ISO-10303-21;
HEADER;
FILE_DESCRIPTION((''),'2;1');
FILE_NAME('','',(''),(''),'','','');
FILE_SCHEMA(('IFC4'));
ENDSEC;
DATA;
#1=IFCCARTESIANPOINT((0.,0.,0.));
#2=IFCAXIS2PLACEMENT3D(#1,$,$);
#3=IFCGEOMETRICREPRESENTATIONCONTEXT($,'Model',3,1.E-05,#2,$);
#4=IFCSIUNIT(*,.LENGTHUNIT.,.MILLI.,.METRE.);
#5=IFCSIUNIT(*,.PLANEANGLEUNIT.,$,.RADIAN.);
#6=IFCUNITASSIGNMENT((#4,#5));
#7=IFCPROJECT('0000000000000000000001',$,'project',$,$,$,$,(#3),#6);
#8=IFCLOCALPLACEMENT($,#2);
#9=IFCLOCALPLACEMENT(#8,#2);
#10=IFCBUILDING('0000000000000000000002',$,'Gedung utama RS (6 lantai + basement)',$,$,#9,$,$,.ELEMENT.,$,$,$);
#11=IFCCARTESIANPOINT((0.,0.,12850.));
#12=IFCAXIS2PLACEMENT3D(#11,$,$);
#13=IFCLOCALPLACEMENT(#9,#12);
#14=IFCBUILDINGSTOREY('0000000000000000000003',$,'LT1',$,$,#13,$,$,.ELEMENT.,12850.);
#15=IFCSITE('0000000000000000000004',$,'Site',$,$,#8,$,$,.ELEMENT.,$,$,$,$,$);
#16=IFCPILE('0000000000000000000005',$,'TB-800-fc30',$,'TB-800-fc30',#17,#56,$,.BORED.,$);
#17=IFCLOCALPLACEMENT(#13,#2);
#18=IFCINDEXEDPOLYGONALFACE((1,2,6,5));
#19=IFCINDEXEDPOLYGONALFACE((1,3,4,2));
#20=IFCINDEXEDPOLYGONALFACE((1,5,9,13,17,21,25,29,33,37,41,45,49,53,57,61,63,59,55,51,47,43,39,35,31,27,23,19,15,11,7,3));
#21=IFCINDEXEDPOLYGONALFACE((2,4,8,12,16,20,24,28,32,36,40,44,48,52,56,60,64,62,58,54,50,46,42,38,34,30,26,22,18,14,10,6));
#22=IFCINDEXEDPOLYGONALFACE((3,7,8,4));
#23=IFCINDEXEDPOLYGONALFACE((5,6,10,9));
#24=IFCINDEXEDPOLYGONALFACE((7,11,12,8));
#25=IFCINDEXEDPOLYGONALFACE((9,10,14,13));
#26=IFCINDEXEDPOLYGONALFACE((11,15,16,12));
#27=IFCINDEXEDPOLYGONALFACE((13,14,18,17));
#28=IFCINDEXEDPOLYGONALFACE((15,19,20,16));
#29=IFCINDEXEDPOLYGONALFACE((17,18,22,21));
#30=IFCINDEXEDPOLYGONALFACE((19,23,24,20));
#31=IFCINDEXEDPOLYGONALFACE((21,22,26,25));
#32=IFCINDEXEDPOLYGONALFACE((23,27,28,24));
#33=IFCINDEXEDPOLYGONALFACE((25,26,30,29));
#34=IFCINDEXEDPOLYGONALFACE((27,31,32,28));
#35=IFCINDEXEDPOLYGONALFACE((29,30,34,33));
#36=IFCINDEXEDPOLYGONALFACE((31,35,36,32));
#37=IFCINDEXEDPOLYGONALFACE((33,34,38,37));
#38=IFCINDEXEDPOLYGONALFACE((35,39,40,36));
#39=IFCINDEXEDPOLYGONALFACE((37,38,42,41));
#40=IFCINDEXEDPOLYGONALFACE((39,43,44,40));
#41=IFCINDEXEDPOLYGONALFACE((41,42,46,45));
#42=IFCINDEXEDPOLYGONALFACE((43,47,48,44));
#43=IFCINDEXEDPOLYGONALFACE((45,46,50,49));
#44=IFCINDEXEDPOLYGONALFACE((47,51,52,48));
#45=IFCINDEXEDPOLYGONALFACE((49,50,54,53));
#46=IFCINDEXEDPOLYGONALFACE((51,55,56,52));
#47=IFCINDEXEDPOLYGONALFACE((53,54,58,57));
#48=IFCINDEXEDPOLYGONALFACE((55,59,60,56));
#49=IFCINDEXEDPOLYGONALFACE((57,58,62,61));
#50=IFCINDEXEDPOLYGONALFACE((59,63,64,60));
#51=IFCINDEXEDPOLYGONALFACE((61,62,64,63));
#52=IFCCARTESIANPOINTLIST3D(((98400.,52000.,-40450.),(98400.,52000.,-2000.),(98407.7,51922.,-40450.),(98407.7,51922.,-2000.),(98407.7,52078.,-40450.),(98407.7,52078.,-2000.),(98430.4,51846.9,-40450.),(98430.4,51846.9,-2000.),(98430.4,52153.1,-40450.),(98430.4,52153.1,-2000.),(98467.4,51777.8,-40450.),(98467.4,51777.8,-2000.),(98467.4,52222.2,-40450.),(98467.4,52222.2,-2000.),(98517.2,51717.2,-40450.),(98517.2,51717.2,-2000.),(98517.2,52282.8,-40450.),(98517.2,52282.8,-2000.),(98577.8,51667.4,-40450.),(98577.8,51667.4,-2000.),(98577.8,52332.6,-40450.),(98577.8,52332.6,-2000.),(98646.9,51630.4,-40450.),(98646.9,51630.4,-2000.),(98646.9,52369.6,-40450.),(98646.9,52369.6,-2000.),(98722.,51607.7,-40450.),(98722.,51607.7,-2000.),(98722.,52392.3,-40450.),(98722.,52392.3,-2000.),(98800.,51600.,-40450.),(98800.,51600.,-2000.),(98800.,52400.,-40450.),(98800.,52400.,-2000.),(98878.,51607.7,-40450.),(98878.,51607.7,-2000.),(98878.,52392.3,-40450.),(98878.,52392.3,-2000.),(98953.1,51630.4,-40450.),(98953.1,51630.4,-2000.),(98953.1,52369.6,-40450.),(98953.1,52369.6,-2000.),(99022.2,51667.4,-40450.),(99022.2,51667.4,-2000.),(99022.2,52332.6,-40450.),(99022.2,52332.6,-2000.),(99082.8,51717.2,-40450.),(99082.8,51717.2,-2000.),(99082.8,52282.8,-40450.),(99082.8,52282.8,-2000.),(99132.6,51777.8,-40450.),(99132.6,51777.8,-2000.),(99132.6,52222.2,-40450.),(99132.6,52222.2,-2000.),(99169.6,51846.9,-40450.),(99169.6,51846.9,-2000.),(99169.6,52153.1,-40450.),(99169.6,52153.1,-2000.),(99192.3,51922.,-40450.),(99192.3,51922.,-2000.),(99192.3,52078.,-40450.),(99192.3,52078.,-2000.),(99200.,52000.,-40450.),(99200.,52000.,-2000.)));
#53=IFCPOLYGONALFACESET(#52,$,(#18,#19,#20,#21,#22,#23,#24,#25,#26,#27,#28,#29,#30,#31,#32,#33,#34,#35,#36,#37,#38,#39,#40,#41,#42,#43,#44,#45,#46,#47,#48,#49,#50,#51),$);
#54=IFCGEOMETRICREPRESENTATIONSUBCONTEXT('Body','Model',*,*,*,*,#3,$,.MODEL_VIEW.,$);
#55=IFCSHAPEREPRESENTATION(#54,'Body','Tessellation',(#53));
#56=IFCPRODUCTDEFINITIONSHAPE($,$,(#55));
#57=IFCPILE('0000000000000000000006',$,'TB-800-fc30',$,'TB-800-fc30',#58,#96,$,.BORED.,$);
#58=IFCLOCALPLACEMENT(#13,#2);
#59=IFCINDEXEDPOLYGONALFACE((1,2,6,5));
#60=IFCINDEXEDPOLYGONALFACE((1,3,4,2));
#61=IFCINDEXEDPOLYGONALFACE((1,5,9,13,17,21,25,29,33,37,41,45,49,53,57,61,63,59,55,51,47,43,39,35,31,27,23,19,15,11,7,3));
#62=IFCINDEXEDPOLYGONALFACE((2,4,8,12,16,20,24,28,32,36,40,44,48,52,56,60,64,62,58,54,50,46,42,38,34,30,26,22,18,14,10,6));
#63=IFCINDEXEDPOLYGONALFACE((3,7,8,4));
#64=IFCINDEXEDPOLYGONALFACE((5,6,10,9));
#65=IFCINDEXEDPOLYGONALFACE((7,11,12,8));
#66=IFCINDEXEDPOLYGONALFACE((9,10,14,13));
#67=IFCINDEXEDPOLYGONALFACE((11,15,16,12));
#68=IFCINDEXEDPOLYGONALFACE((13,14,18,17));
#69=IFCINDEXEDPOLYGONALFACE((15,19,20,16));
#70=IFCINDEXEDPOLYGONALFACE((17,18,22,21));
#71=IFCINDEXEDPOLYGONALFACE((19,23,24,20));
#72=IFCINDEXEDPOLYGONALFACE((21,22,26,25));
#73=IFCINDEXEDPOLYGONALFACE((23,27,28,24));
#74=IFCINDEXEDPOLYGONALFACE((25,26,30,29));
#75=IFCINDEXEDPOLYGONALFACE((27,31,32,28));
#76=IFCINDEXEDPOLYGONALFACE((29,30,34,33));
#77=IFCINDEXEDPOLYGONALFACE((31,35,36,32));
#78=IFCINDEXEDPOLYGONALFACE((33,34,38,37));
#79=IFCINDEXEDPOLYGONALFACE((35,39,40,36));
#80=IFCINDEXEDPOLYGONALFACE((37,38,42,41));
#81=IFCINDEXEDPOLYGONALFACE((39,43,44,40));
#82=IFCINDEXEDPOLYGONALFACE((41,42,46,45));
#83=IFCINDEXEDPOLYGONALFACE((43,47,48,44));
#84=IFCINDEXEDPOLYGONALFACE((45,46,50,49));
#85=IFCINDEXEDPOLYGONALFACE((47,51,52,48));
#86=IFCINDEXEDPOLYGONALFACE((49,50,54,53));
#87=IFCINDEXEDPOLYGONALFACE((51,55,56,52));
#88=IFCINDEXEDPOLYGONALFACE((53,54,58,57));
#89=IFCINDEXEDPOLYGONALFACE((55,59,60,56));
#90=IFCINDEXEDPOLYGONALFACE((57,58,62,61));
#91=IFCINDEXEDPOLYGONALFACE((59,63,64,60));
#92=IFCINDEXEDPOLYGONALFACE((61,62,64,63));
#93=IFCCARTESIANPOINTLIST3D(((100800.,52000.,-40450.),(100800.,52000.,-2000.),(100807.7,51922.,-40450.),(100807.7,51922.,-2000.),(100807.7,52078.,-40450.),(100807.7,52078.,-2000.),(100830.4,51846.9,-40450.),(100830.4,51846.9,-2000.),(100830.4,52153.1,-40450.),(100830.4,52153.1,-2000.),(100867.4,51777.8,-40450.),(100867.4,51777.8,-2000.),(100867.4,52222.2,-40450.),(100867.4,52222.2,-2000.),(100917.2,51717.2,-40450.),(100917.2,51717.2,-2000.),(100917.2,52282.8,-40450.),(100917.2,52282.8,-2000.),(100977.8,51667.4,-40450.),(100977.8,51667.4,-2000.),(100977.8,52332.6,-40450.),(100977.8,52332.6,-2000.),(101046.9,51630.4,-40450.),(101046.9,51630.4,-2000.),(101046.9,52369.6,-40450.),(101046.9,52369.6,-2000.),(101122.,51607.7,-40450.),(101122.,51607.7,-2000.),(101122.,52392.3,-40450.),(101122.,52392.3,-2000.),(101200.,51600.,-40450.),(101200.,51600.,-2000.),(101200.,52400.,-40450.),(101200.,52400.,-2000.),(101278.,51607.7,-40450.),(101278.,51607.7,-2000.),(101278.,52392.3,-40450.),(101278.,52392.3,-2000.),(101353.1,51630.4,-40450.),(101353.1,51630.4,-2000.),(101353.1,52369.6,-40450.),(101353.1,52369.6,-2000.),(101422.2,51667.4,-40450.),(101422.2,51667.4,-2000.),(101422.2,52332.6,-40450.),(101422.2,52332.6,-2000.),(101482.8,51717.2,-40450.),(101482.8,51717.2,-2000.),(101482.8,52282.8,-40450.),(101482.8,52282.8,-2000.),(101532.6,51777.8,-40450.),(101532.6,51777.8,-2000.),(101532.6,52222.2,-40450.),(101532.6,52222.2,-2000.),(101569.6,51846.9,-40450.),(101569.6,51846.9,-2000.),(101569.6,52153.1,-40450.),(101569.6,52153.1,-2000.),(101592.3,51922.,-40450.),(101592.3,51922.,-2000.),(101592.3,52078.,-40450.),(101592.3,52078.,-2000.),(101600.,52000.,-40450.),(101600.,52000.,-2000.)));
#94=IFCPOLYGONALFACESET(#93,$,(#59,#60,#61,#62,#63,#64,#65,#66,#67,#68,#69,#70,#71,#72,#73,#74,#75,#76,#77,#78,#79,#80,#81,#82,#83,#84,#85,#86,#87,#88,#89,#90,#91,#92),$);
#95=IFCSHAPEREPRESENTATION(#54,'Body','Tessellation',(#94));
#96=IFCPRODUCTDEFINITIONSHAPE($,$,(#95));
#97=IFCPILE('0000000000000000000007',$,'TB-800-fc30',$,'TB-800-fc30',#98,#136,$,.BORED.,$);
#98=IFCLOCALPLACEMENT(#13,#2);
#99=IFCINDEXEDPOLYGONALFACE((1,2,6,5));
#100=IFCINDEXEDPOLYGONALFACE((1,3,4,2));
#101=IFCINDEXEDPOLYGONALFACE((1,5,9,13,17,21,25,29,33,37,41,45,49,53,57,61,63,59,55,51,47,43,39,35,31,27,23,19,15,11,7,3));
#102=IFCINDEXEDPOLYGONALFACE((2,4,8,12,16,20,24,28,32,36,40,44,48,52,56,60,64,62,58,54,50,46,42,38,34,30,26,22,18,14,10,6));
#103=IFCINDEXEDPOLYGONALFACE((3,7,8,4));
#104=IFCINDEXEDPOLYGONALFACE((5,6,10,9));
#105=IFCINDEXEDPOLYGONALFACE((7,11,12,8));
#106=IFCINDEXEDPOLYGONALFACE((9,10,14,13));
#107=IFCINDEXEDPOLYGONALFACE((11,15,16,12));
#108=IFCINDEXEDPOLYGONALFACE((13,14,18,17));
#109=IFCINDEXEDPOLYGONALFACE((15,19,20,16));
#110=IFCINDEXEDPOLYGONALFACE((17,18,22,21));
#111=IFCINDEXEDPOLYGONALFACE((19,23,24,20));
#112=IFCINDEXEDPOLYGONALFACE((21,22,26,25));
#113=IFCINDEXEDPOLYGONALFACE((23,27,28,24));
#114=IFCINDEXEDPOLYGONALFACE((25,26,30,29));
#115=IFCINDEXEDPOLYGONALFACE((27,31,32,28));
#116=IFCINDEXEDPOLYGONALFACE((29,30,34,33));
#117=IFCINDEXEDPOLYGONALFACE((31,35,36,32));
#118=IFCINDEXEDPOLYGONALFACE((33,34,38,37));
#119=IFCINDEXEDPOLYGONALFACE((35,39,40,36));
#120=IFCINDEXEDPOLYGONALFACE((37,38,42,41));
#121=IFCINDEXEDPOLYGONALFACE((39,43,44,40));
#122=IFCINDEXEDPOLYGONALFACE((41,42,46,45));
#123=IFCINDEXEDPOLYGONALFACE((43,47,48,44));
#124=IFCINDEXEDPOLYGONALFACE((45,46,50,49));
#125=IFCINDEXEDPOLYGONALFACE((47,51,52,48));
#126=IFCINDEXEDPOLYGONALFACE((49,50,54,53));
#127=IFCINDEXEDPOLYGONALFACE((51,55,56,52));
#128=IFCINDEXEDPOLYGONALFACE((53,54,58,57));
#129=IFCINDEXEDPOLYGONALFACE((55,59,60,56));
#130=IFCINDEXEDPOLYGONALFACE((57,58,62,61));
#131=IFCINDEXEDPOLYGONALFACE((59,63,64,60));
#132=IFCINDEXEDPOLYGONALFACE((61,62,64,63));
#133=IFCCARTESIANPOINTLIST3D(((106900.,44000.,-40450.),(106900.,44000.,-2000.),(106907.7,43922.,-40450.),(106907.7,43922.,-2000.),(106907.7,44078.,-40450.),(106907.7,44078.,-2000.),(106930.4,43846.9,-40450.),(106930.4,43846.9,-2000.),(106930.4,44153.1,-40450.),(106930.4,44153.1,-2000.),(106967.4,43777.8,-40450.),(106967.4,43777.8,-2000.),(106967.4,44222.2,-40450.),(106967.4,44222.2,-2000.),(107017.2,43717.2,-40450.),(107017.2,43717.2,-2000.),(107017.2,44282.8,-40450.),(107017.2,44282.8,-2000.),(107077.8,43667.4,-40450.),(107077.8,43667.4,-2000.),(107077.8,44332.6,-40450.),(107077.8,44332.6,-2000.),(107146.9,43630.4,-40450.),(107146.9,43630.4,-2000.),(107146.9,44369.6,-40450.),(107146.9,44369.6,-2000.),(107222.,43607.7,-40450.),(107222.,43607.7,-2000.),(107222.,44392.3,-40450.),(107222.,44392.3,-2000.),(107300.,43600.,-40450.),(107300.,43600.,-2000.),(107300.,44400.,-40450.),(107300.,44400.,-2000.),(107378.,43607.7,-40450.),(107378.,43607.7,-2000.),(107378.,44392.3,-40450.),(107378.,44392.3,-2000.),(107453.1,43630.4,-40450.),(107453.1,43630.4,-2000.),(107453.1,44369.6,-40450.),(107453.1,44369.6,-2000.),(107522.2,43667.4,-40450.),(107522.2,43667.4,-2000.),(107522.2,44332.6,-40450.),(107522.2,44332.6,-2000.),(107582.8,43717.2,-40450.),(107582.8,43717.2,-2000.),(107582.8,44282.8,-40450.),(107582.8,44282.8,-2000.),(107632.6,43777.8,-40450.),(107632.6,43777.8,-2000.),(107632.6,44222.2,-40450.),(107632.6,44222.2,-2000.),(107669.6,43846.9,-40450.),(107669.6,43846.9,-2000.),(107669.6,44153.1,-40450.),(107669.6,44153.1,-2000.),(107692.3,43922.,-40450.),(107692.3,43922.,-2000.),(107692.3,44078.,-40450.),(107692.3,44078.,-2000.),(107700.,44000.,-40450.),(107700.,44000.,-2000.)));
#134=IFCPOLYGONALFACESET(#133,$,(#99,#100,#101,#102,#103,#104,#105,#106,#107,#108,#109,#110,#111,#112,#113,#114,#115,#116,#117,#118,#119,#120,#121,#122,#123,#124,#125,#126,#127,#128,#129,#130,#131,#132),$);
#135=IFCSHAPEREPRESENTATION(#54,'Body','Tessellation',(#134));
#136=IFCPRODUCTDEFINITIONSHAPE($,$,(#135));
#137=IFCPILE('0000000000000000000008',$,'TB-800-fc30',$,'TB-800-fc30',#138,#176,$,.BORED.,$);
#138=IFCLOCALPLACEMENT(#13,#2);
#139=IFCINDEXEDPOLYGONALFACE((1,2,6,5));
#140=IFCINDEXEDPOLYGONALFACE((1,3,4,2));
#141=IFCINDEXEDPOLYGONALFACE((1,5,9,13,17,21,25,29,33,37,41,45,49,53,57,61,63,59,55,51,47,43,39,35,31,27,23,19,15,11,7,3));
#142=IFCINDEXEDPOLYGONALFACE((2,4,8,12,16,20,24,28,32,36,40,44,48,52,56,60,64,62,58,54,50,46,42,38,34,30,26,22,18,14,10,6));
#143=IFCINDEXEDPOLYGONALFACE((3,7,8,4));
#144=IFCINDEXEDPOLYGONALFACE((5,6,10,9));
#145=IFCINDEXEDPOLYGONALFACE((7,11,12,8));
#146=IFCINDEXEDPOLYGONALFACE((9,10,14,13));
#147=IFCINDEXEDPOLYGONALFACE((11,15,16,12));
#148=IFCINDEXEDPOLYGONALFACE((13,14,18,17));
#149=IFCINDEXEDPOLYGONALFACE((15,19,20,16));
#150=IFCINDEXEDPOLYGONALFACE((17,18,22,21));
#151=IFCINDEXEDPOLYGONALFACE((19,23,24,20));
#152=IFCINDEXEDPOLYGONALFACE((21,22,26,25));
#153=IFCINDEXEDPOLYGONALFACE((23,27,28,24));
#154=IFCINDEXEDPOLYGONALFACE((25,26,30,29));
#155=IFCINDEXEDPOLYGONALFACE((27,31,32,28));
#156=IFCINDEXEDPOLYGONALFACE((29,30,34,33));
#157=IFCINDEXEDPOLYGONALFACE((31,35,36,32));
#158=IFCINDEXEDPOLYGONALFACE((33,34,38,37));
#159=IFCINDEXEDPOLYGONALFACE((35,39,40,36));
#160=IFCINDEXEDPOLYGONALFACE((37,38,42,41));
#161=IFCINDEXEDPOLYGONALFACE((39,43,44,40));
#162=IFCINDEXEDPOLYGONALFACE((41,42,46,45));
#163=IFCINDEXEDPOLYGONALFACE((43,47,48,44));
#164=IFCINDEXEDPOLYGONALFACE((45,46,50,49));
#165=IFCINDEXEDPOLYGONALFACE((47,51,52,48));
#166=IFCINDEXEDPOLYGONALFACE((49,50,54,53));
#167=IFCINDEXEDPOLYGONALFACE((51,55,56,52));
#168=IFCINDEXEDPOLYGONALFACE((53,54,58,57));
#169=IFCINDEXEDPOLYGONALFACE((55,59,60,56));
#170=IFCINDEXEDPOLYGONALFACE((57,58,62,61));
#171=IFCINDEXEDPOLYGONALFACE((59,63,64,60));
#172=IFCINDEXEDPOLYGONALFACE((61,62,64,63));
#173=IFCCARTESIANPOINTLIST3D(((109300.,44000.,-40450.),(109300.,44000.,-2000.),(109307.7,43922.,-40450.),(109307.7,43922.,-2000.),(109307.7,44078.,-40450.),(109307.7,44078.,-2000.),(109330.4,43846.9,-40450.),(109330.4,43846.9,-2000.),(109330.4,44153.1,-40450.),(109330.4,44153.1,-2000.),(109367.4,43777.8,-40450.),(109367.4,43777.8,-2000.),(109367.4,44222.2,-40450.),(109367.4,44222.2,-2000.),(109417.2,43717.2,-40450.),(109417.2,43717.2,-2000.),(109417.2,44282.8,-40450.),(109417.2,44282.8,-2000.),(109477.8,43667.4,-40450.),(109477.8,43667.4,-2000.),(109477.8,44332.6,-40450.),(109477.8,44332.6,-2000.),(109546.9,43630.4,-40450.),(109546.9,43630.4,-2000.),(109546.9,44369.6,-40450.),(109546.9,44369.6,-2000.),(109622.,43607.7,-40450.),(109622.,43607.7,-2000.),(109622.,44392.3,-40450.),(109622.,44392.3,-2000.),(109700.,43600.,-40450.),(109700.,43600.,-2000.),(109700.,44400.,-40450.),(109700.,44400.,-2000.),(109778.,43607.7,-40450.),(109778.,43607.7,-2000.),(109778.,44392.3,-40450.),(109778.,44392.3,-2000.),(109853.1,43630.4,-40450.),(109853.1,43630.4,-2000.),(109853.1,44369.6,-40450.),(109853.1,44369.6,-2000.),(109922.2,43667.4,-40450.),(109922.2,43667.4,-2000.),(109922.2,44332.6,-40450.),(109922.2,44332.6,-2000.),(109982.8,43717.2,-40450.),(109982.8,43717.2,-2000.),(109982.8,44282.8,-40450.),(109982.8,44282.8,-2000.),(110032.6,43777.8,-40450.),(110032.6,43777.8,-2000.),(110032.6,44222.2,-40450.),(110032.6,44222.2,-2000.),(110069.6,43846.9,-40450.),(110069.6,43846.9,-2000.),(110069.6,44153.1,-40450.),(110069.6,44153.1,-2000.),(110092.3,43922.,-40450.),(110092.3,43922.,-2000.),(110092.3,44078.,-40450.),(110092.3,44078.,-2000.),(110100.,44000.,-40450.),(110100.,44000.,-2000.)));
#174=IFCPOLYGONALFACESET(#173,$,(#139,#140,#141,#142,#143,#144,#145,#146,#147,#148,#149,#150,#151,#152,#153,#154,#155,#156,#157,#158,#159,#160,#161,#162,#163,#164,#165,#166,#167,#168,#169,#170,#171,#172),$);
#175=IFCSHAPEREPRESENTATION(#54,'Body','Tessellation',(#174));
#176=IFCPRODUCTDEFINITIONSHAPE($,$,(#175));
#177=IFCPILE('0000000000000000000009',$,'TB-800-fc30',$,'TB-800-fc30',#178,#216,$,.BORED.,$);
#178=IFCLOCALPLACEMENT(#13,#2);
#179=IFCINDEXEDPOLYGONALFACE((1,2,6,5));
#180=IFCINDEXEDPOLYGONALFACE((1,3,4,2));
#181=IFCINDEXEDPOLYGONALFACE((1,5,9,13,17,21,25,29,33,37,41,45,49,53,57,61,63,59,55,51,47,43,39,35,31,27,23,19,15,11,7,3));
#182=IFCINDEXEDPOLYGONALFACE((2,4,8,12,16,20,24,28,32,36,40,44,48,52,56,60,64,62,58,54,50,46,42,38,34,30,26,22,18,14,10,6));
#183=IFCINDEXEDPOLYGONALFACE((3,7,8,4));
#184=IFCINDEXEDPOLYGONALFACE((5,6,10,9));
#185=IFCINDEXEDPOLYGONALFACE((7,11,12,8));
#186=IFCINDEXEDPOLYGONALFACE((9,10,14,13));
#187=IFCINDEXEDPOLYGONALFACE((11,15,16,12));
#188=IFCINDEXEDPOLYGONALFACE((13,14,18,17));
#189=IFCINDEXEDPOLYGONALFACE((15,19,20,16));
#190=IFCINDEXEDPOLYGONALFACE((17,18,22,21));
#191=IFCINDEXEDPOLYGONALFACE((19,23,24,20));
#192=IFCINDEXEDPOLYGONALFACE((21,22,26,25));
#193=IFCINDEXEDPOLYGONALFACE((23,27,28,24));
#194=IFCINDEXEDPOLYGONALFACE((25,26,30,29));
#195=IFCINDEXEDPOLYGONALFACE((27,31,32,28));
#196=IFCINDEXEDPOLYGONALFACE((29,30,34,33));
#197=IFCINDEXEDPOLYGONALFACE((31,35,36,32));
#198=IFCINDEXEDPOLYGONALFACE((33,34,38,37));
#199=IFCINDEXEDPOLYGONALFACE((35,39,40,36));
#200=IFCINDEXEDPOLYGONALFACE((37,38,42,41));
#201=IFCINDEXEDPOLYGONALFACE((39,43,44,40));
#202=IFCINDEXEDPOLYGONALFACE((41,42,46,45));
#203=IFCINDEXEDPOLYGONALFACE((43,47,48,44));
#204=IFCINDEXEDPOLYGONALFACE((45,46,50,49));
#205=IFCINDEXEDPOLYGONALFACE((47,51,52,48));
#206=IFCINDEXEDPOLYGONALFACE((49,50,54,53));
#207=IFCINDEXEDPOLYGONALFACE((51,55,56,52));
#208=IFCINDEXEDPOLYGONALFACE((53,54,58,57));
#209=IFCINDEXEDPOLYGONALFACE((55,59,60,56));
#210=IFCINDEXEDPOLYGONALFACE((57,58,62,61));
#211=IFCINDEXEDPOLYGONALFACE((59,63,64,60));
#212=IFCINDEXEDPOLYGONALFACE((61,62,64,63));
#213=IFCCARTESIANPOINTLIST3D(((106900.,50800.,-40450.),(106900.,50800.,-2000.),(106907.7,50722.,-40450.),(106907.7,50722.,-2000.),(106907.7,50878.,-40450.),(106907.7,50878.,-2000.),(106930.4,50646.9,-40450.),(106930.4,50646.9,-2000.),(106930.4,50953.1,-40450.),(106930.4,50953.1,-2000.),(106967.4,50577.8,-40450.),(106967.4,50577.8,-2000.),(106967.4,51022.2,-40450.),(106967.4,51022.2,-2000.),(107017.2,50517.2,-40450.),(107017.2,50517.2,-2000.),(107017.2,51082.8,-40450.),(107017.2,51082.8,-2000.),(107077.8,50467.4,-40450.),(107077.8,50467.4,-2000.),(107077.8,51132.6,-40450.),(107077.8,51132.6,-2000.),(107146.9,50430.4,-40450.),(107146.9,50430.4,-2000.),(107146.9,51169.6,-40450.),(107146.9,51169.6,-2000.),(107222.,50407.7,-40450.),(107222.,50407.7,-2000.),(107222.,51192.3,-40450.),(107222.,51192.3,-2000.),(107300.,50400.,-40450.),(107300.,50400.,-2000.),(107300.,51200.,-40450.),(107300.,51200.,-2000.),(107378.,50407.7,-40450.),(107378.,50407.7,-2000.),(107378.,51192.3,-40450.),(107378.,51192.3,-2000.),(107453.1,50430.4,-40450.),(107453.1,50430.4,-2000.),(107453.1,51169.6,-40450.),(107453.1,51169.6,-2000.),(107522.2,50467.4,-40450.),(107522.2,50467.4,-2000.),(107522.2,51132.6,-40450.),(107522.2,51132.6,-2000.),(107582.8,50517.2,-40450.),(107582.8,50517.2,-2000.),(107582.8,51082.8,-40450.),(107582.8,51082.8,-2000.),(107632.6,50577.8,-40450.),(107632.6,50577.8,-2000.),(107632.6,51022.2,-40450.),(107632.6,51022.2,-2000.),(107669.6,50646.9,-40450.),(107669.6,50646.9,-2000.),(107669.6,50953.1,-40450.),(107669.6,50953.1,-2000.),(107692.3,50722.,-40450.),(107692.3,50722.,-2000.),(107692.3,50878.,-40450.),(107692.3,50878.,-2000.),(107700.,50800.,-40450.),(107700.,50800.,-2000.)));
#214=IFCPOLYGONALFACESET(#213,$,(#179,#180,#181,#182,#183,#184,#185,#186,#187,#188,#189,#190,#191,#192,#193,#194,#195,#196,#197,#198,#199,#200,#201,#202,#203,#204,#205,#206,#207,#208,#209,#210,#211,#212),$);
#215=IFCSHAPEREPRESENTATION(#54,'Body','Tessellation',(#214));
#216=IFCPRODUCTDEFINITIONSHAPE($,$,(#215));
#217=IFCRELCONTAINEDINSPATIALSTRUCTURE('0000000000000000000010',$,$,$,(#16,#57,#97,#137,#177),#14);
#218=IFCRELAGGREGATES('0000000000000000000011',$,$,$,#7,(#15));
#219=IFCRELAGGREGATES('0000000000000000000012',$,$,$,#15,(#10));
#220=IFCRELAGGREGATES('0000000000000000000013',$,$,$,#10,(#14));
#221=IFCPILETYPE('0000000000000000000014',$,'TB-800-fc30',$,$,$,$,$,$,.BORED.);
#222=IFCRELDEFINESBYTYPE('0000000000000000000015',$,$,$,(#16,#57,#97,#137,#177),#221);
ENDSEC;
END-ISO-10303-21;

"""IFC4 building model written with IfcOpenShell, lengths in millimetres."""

from ifc_helpers import new_model, si_unit, frame, origin, origin_2d, place, context, subcontext, project, spatial, circle, extrude, material_profile, profile_set, profile_usage, type_object, element, save


model = new_model("IFC4")

# Units and contexts
model_context = context("Model", 3, precision=1e-05, world=origin())
body_context = subcontext(model_context, "Body", "Model", "MODEL_VIEW")
ifc_project = project(units=[si_unit("LENGTHUNIT", "METRE", prefix="MILLI"), si_unit("PLANEANGLEUNIT", "RADIAN")], contexts=[model_context])

# Site, building, storey
site_placement = place(None, origin())
site = spatial("IfcSite", under=ifc_project, at=site_placement, Name="Site", CompositionType="ELEMENT")
building_placement = place(site_placement, origin())
building = spatial("IfcBuilding", under=site, at=building_placement, Name="Gedung utama RS (6 lantai + basement)", CompositionType="ELEMENT")
storey_placement = place(building_placement, frame((0.0, 0.0, 12850.0)))
storey = spatial("IfcBuildingStorey", under=building, at=storey_placement, Name="LT1", CompositionType="ELEMENT", Elevation=12850.0)

# Piles
ifc_material_profile_1 = material_profile(None, circle(Radius=400.0, at=origin_2d()), Name="TB-800-fc30")
ifc_profile_set_1 = profile_set([ifc_material_profile_1], Name="TB-800-fc30")
ifc_profile_usage_1 = profile_usage(ifc_profile_set_1, cardinal=5)
pile_type = type_object("IfcPileType", Name="TB-800-fc30", PredefinedType="BORED", material=ifc_profile_set_1)
for number, where, z_axis, x_axis, name in (
    (1, (98800.0, 52000.0, -40450.0), (0.0, 0.0, 1.0), (1.0, 0.0, 0.0), "TB-800-fc30"),
    (2, (101200.0, 52000.0, -40450.0), (0.0, 0.0, 1.0), (1.0, 0.0, 0.0), "TB-800-fc30"),
    (3, (107300.0, 44000.0, -40450.0), (0.0, 0.0, 1.0), (1.0, 0.0, 0.0), "TB-800-fc30"),
    (4, (109700.0, 44000.0, -40450.0), (0.0, 0.0, 1.0), (1.0, 0.0, 0.0), "TB-800-fc30"),
    (5, (107300.0, 50800.0, -40450.0), (0.0, 0.0, 1.0), (1.0, 0.0, 0.0), "TB-800-fc30"),
):
    element("IfcPile", number, at=place(storey_placement, frame(where, z_axis=z_axis, x_axis=x_axis)), inside=storey, type_object=pile_type, material=ifc_profile_usage_1, Name=name, ObjectType="TB-800-fc30", PredefinedType="BORED", context=body_context, shape_type="SweptSolid", body=[
        extrude(circle(Radius=400.0, at=origin_2d()), origin(), (0.0, 0.0, 1.0), 38450.0),
    ])

save(model, "model.ifc")
